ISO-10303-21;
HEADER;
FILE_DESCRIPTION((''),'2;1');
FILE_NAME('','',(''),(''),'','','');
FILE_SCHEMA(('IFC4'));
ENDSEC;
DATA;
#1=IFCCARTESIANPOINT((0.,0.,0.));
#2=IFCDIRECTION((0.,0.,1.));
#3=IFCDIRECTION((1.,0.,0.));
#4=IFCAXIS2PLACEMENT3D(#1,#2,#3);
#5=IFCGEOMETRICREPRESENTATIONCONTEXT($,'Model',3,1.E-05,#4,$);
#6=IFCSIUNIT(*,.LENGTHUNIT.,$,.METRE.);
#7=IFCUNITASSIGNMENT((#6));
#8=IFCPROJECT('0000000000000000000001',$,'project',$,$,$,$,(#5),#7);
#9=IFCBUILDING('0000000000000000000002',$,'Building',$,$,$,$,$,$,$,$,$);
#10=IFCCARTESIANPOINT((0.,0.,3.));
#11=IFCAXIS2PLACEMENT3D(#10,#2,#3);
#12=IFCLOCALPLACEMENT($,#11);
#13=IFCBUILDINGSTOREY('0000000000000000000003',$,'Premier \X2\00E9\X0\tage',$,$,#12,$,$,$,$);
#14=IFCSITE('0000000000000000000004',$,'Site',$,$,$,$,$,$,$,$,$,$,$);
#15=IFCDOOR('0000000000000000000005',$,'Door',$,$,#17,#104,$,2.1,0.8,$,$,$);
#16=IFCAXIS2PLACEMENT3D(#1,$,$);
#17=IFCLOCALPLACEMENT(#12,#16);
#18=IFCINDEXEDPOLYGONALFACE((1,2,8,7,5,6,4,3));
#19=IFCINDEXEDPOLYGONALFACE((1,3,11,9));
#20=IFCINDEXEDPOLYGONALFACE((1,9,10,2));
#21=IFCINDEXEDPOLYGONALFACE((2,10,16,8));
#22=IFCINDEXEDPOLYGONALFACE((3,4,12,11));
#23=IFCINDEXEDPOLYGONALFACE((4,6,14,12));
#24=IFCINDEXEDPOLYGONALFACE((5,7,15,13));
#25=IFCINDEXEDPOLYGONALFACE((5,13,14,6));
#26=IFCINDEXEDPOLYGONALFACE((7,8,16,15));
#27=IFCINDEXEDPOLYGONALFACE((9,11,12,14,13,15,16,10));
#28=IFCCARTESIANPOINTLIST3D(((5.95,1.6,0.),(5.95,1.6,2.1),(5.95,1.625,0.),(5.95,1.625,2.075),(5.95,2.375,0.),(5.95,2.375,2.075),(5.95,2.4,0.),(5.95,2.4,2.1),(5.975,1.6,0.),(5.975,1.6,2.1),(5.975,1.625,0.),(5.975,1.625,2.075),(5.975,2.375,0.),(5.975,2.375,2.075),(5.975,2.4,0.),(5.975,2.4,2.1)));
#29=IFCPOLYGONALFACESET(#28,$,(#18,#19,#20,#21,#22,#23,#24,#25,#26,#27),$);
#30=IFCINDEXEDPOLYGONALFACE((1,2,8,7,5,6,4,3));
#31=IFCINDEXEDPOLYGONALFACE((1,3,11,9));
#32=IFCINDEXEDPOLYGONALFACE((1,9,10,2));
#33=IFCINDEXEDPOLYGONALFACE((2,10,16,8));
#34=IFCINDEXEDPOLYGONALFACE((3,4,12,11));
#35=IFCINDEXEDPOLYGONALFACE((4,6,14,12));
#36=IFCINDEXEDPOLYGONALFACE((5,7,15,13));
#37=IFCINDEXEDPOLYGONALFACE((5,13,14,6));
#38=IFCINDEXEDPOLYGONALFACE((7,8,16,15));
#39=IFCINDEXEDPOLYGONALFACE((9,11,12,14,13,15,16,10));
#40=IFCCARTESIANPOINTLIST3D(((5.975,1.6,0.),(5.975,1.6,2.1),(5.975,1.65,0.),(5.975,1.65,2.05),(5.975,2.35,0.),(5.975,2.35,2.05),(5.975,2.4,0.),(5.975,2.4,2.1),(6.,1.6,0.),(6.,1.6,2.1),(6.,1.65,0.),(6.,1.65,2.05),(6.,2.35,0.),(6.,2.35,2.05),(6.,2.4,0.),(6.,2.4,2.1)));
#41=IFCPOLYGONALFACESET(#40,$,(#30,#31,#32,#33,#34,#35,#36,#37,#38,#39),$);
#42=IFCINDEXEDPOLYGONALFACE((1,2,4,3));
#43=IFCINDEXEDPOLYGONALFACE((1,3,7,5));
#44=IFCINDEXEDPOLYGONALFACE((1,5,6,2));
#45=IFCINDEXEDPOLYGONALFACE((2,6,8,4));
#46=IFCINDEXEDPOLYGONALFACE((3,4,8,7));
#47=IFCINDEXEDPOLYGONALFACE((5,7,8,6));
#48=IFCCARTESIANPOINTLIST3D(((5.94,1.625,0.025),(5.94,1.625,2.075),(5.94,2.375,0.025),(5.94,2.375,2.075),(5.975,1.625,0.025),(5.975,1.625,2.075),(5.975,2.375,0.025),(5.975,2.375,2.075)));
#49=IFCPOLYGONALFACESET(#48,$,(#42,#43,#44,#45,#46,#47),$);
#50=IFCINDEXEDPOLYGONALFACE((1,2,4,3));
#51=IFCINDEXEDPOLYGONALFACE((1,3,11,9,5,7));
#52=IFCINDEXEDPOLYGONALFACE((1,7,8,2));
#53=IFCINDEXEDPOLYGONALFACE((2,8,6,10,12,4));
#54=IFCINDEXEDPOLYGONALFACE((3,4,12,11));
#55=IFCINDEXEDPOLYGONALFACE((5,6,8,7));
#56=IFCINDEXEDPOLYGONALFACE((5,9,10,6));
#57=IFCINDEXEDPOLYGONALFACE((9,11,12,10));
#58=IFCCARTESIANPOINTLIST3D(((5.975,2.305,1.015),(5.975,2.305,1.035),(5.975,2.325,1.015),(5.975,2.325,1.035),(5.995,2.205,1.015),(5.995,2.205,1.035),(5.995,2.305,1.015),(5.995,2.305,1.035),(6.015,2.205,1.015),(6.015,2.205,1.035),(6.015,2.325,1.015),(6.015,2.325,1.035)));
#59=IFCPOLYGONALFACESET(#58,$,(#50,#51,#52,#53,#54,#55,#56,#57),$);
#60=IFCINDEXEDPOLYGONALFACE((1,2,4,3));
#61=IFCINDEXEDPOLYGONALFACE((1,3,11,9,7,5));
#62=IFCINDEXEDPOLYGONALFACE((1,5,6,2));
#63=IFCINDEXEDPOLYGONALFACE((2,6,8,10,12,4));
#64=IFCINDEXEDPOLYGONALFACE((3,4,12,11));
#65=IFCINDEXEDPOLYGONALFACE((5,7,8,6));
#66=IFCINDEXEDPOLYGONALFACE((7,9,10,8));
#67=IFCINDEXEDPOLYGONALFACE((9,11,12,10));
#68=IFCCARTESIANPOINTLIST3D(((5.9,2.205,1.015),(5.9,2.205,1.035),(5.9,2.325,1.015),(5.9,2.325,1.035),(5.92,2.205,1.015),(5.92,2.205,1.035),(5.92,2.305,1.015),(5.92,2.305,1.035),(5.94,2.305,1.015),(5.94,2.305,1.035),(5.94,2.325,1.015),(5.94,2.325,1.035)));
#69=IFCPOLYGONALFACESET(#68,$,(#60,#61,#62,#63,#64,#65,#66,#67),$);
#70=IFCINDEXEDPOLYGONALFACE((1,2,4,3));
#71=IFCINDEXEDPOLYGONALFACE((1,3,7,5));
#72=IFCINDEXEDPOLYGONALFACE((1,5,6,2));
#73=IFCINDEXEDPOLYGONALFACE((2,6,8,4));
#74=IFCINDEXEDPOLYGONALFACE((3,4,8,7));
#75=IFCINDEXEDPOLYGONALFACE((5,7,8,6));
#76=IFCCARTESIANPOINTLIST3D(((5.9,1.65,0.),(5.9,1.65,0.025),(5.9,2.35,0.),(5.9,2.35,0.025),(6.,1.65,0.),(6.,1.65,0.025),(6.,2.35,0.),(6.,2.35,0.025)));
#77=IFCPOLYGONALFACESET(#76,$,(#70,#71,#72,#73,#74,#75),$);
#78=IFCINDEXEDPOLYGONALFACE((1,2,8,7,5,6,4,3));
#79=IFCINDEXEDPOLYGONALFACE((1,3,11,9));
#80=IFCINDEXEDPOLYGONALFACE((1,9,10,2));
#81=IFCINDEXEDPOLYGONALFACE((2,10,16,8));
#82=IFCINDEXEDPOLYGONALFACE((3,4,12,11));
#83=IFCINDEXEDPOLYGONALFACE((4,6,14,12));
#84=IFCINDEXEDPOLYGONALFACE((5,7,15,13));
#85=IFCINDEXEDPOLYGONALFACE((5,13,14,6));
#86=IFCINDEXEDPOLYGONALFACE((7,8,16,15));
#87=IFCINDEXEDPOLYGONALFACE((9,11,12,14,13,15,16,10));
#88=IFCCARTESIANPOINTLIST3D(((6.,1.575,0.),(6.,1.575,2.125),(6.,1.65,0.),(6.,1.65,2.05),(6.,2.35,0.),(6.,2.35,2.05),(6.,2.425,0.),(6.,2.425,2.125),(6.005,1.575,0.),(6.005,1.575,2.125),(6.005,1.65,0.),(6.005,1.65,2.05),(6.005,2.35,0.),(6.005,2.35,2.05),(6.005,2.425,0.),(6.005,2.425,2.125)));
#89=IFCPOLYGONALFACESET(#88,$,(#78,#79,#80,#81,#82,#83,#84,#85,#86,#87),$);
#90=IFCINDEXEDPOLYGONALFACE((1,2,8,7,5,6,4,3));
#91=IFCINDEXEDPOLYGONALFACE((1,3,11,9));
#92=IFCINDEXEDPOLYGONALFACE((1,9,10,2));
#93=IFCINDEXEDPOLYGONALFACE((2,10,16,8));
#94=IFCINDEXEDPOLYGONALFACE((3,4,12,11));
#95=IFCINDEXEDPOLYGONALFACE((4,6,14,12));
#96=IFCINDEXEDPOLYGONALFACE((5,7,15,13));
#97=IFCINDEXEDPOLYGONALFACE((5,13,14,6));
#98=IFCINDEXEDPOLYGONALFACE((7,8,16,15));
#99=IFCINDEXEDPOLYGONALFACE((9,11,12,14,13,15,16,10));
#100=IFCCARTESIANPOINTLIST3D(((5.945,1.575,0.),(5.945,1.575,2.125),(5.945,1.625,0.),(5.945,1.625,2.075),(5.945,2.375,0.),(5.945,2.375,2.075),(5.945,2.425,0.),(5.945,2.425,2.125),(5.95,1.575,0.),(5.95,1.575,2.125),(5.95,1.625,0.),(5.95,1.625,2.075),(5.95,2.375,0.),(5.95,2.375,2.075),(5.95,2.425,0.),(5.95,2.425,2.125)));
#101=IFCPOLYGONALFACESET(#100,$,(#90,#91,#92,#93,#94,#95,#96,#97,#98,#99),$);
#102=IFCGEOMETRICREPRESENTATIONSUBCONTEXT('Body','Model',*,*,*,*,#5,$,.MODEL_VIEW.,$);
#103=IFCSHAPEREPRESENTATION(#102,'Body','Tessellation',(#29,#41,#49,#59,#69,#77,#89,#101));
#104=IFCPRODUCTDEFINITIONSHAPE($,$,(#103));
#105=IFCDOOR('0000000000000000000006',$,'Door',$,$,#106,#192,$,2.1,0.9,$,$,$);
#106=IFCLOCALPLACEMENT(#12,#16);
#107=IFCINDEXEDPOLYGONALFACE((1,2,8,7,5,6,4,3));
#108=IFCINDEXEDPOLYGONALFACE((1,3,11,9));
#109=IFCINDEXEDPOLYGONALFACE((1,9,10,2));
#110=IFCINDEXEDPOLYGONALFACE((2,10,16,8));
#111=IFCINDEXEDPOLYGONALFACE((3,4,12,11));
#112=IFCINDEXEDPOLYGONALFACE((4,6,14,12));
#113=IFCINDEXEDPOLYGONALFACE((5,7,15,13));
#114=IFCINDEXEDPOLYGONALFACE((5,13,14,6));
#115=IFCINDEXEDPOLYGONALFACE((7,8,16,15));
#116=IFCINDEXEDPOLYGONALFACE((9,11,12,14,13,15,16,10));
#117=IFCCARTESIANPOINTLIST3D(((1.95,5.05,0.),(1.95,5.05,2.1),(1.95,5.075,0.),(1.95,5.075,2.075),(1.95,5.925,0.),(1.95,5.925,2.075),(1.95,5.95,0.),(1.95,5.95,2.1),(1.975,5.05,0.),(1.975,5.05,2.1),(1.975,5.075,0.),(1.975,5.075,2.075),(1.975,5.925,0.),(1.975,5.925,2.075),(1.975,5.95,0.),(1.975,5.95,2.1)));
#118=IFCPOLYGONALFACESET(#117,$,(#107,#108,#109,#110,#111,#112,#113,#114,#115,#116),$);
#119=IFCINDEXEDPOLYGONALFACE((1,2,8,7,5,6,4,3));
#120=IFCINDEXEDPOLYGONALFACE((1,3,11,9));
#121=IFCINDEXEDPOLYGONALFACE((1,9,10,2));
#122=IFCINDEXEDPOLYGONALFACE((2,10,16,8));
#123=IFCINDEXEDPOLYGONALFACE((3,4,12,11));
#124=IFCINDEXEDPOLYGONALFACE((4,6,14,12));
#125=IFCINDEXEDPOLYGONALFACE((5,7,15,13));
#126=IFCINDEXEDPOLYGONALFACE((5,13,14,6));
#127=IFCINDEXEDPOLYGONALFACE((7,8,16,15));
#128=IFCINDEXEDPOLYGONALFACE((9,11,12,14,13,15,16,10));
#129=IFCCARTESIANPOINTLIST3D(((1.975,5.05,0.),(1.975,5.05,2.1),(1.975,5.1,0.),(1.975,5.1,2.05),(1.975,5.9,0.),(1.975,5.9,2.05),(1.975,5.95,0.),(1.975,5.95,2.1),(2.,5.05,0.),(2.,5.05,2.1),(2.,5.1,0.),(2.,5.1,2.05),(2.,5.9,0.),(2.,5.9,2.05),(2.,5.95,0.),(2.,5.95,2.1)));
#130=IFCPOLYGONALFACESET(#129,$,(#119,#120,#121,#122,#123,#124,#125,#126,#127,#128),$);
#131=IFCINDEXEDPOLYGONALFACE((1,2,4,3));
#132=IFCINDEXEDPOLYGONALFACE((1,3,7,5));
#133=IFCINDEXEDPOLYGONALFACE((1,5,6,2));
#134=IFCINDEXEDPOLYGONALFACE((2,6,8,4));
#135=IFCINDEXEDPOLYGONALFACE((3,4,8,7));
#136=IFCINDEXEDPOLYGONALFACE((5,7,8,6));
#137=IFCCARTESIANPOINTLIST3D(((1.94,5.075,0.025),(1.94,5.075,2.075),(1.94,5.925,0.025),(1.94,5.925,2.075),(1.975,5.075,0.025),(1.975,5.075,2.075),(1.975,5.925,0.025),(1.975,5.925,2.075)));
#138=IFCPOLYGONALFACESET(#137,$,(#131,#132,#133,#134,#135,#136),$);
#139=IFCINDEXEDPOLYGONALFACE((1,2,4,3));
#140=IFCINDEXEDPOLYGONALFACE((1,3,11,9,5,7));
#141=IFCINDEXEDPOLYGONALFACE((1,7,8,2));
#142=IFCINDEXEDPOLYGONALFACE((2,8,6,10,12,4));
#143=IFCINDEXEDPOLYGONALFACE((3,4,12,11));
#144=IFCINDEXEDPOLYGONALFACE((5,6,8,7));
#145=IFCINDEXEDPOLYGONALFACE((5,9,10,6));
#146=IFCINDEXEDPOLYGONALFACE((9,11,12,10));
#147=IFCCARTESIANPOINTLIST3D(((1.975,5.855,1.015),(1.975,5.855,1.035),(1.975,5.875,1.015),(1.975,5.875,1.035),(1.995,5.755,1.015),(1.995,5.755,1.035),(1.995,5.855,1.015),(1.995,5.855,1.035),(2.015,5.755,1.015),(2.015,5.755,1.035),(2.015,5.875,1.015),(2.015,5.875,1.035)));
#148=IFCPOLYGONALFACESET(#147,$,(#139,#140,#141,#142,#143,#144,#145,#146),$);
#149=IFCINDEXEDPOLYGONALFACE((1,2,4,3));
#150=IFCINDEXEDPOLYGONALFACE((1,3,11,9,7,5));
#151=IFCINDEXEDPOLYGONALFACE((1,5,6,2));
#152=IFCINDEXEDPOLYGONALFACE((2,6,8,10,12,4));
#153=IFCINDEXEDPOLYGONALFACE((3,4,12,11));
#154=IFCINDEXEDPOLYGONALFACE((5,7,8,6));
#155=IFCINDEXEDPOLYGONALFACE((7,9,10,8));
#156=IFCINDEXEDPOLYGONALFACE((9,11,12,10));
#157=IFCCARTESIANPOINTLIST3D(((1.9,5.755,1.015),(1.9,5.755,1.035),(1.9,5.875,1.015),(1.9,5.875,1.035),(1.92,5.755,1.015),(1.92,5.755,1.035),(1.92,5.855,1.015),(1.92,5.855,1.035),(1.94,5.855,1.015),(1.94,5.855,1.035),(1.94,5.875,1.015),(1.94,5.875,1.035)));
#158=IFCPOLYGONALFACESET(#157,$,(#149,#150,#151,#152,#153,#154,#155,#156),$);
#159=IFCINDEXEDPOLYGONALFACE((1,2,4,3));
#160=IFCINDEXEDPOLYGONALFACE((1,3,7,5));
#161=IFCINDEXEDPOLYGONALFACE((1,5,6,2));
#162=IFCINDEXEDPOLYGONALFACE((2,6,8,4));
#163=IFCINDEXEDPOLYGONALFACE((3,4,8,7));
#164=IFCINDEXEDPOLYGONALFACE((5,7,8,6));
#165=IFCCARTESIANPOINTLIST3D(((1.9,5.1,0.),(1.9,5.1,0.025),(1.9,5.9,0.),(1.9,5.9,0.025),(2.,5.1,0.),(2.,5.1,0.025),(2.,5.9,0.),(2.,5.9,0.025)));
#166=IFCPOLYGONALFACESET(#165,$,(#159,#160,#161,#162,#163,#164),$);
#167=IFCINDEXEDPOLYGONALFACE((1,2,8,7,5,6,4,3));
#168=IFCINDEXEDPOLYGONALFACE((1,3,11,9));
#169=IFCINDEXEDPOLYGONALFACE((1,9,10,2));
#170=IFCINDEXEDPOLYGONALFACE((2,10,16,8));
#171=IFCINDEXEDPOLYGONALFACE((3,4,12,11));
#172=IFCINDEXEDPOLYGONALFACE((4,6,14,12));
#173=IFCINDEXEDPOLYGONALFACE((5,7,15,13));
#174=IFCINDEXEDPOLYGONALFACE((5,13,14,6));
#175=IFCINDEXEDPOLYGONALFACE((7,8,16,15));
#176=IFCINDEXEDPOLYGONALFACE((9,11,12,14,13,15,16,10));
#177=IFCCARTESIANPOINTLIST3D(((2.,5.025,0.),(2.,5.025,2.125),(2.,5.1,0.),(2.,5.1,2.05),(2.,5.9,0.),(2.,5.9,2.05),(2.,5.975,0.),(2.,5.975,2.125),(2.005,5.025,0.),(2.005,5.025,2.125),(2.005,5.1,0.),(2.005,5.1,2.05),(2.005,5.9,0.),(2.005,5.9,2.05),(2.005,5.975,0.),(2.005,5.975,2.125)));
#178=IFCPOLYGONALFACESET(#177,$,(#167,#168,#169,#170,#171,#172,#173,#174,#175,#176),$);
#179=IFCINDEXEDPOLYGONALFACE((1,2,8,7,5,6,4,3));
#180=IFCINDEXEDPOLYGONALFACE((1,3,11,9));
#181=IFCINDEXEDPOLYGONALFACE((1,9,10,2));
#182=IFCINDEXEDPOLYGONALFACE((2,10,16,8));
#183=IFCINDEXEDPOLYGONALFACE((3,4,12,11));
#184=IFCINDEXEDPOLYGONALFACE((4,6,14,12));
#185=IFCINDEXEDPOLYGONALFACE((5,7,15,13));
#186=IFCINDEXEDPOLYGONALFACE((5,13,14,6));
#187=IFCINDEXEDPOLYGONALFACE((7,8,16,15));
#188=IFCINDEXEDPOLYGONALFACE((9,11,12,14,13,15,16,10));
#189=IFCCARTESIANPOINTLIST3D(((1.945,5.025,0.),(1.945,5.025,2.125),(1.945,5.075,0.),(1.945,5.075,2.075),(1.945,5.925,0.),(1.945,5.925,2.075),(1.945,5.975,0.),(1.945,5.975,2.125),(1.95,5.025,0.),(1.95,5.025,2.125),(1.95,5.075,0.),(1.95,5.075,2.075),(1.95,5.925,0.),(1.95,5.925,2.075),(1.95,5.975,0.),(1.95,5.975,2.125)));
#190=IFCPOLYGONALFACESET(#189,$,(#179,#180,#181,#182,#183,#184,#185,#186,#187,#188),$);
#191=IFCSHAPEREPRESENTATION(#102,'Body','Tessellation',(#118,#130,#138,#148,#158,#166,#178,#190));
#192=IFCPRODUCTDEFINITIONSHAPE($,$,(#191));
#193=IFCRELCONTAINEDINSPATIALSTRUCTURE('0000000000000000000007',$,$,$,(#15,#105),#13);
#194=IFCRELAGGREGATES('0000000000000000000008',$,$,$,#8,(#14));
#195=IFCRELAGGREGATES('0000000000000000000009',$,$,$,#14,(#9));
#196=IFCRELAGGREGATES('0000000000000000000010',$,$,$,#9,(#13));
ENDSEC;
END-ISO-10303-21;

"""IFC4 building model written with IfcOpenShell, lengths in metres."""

from ifc_helpers import new_model, si_unit, frame, origin_with_axes, place, context, subcontext, project, spatial, line, indexed_curve, outline, extrude, element, save


model = new_model("IFC4")

# Units and contexts
model_context = context("Model", 3, precision=1e-05, world=origin_with_axes())
body_context = subcontext(model_context, "Body", "Model", "MODEL_VIEW")
ifc_project = project(units=[si_unit("LENGTHUNIT", "METRE")], contexts=[model_context])

# Site, building, storey
site = spatial("IfcSite", under=ifc_project, Name="Site")
building = spatial("IfcBuilding", under=site, Name="Building")
storey_placement = place(None, frame((0.0, 0.0, 3.0), z_axis=(0.0, 0.0, 1.0), x_axis=(1.0, 0.0, 0.0)))
storey = spatial("IfcBuildingStorey", under=building, at=storey_placement, Name="Premier étage")

# Doors
door_1_placement = place(storey_placement, frame((6.0, 1.6, 0.0), z_axis=(0.0, 0.0, 1.0), x_axis=(0.0, 1.0, 0.0)))
element("IfcDoor", 1, at=door_1_placement, inside=storey, Name="Door", OverallHeight=2.1, OverallWidth=0.8, context=body_context, shape_type="SweptSolid", body=[
    extrude(outline(indexed_curve([(0.0, 0.0), (0.0, 2.1), (0.8, 2.1), (0.8, 0.0), (0.775, 0.0), (0.775, 2.075), (0.025, 2.075), (0.025, 0.0)], segments=[line(1, 2, 3, 4, 5, 6, 7, 8, 1)])), frame((0.0, 0.025, 0.0), z_axis=(0.0, -1.0, 0.0), x_axis=(1.0, 0.0, 0.0)), (0.0, 0.0, -1.0), 0.025),
    extrude(outline(indexed_curve([(0.0, 0.0), (0.0, 2.1), (0.8, 2.1), (0.8, 0.0), (0.75, 0.0), (0.75, 2.05), (0.05, 2.05), (0.05, 0.0)], segments=[line(1, 2, 3, 4, 5, 6, 7, 8, 1)])), frame((0.0, 0.0, 0.0), z_axis=(0.0, -1.0, 0.0), x_axis=(1.0, 0.0, 0.0)), (0.0, 0.0, -1.0), 0.025),
    extrude(outline(indexed_curve([(0.0, 0.0), (0.75, 0.0), (0.75, 0.035), (0.0, 0.035)], segments=[line(1, 2, 3, 4, 1)])), frame((0.025, 0.025, 0.025), z_axis=(0.0, 0.0, 1.0), x_axis=(1.0, 0.0, 0.0)), (0.0, 0.0, 1.0), 2.05),
    extrude(outline(indexed_curve([(0.0, 0.0), (0.0, -0.04), (-0.12, -0.04), (-0.12, -0.02), (-0.02, -0.02), (-0.02, 0.0)], segments=[line(1, 2, 3, 4, 5, 6, 1)])), frame((0.725, 0.025, 1.015), z_axis=(0.0, 0.0, 1.0), x_axis=(1.0, 0.0, 0.0)), (0.0, 0.0, 1.0), 0.02),
    extrude(outline(indexed_curve([(0.0, 0.0), (0.0, 0.04), (-0.12, 0.04), (-0.12, 0.02), (-0.02, 0.02), (-0.02, 0.0)], segments=[line(1, 2, 3, 4, 5, 6, 1)])), frame((0.725, 0.06, 1.015), z_axis=(0.0, 0.0, 1.0), x_axis=(1.0, 0.0, 0.0)), (0.0, 0.0, 1.0), 0.02),
    extrude(outline(indexed_curve([(0.0, 0.0), (0.7, 0.0), (0.7, 0.1), (0.0, 0.1)], segments=[line(1, 2, 3, 4, 1)])), frame((0.05, 0.0, 0.0), z_axis=(0.0, 0.0, 1.0), x_axis=(1.0, 0.0, 0.0)), (0.0, 0.0, 1.0), 0.025),
    extrude(outline(indexed_curve([(0.0, 0.0), (0.0, 2.125), (0.85, 2.125), (0.85, 0.0), (0.775, 0.0), (0.775, 2.05), (0.075, 2.05), (0.075, 0.0)], segments=[line(1, 2, 3, 4, 5, 6, 7, 8, 1)])), frame((-0.025, -0.005, 0.0), z_axis=(0.0, -1.0, 0.0), x_axis=(1.0, 0.0, 0.0)), (0.0, 0.0, -1.0), 0.005),
    extrude(outline(indexed_curve([(0.0, 0.0), (0.0, 2.125), (0.85, 2.125), (0.85, 0.0), (0.8, 0.0), (0.8, 2.075), (0.05, 2.075), (0.05, 0.0)], segments=[line(1, 2, 3, 4, 5, 6, 7, 8, 1)])), frame((-0.025, 0.05, 0.0), z_axis=(0.0, -1.0, 0.0), x_axis=(1.0, 0.0, 0.0)), (0.0, 0.0, -1.0), 0.005),
])
door_2_placement = place(storey_placement, frame((2.0, 5.05, 0.0), z_axis=(0.0, 0.0, 1.0), x_axis=(0.0, 1.0, 0.0)))
element("IfcDoor", 2, at=door_2_placement, inside=storey, Name="Door", OverallHeight=2.1, OverallWidth=0.9, context=body_context, shape_type="SweptSolid", body=[
    extrude(outline(indexed_curve([(0.0, 0.0), (0.0, 2.1), (0.9, 2.1), (0.9, 0.0), (0.875, 0.0), (0.875, 2.075), (0.025, 2.075), (0.025, 0.0)], segments=[line(1, 2, 3, 4, 5, 6, 7, 8, 1)])), frame((0.0, 0.025, 0.0), z_axis=(0.0, -1.0, 0.0), x_axis=(1.0, 0.0, 0.0)), (0.0, 0.0, -1.0), 0.025),
    extrude(outline(indexed_curve([(0.0, 0.0), (0.0, 2.1), (0.9, 2.1), (0.9, 0.0), (0.85, 0.0), (0.85, 2.05), (0.05, 2.05), (0.05, 0.0)], segments=[line(1, 2, 3, 4, 5, 6, 7, 8, 1)])), frame((0.0, 0.0, 0.0), z_axis=(0.0, -1.0, 0.0), x_axis=(1.0, 0.0, 0.0)), (0.0, 0.0, -1.0), 0.025),
    extrude(outline(indexed_curve([(0.0, 0.0), (0.85, 0.0), (0.85, 0.035), (0.0, 0.035)], segments=[line(1, 2, 3, 4, 1)])), frame((0.025, 0.025, 0.025), z_axis=(0.0, 0.0, 1.0), x_axis=(1.0, 0.0, 0.0)), (0.0, 0.0, 1.0), 2.05),
    extrude(outline(indexed_curve([(0.0, 0.0), (0.0, -0.04), (-0.12, -0.04), (-0.12, -0.02), (-0.02, -0.02), (-0.02, 0.0)], segments=[line(1, 2, 3, 4, 5, 6, 1)])), frame((0.825, 0.025, 1.015), z_axis=(0.0, 0.0, 1.0), x_axis=(1.0, 0.0, 0.0)), (0.0, 0.0, 1.0), 0.02),
    extrude(outline(indexed_curve([(0.0, 0.0), (0.0, 0.04), (-0.12, 0.04), (-0.12, 0.02), (-0.02, 0.02), (-0.02, 0.0)], segments=[line(1, 2, 3, 4, 5, 6, 1)])), frame((0.825, 0.06, 1.015), z_axis=(0.0, 0.0, 1.0), x_axis=(1.0, 0.0, 0.0)), (0.0, 0.0, 1.0), 0.02),
    extrude(outline(indexed_curve([(0.0, 0.0), (0.8, 0.0), (0.8, 0.1), (0.0, 0.1)], segments=[line(1, 2, 3, 4, 1)])), frame((0.05, 0.0, 0.0), z_axis=(0.0, 0.0, 1.0), x_axis=(1.0, 0.0, 0.0)), (0.0, 0.0, 1.0), 0.025),
    extrude(outline(indexed_curve([(0.0, 0.0), (0.0, 2.125), (0.95, 2.125), (0.95, 0.0), (0.875, 0.0), (0.875, 2.05), (0.075, 2.05), (0.075, 0.0)], segments=[line(1, 2, 3, 4, 5, 6, 7, 8, 1)])), frame((-0.025, -0.005, 0.0), z_axis=(0.0, -1.0, 0.0), x_axis=(1.0, 0.0, 0.0)), (0.0, 0.0, -1.0), 0.005),
    extrude(outline(indexed_curve([(0.0, 0.0), (0.0, 2.125), (0.95, 2.125), (0.95, 0.0), (0.9, 0.0), (0.9, 2.075), (0.05, 2.075), (0.05, 0.0)], segments=[line(1, 2, 3, 4, 5, 6, 7, 8, 1)])), frame((-0.025, 0.05, 0.0), z_axis=(0.0, -1.0, 0.0), x_axis=(1.0, 0.0, 0.0)), (0.0, 0.0, -1.0), 0.005),
])

save(model, "model.ifc")
